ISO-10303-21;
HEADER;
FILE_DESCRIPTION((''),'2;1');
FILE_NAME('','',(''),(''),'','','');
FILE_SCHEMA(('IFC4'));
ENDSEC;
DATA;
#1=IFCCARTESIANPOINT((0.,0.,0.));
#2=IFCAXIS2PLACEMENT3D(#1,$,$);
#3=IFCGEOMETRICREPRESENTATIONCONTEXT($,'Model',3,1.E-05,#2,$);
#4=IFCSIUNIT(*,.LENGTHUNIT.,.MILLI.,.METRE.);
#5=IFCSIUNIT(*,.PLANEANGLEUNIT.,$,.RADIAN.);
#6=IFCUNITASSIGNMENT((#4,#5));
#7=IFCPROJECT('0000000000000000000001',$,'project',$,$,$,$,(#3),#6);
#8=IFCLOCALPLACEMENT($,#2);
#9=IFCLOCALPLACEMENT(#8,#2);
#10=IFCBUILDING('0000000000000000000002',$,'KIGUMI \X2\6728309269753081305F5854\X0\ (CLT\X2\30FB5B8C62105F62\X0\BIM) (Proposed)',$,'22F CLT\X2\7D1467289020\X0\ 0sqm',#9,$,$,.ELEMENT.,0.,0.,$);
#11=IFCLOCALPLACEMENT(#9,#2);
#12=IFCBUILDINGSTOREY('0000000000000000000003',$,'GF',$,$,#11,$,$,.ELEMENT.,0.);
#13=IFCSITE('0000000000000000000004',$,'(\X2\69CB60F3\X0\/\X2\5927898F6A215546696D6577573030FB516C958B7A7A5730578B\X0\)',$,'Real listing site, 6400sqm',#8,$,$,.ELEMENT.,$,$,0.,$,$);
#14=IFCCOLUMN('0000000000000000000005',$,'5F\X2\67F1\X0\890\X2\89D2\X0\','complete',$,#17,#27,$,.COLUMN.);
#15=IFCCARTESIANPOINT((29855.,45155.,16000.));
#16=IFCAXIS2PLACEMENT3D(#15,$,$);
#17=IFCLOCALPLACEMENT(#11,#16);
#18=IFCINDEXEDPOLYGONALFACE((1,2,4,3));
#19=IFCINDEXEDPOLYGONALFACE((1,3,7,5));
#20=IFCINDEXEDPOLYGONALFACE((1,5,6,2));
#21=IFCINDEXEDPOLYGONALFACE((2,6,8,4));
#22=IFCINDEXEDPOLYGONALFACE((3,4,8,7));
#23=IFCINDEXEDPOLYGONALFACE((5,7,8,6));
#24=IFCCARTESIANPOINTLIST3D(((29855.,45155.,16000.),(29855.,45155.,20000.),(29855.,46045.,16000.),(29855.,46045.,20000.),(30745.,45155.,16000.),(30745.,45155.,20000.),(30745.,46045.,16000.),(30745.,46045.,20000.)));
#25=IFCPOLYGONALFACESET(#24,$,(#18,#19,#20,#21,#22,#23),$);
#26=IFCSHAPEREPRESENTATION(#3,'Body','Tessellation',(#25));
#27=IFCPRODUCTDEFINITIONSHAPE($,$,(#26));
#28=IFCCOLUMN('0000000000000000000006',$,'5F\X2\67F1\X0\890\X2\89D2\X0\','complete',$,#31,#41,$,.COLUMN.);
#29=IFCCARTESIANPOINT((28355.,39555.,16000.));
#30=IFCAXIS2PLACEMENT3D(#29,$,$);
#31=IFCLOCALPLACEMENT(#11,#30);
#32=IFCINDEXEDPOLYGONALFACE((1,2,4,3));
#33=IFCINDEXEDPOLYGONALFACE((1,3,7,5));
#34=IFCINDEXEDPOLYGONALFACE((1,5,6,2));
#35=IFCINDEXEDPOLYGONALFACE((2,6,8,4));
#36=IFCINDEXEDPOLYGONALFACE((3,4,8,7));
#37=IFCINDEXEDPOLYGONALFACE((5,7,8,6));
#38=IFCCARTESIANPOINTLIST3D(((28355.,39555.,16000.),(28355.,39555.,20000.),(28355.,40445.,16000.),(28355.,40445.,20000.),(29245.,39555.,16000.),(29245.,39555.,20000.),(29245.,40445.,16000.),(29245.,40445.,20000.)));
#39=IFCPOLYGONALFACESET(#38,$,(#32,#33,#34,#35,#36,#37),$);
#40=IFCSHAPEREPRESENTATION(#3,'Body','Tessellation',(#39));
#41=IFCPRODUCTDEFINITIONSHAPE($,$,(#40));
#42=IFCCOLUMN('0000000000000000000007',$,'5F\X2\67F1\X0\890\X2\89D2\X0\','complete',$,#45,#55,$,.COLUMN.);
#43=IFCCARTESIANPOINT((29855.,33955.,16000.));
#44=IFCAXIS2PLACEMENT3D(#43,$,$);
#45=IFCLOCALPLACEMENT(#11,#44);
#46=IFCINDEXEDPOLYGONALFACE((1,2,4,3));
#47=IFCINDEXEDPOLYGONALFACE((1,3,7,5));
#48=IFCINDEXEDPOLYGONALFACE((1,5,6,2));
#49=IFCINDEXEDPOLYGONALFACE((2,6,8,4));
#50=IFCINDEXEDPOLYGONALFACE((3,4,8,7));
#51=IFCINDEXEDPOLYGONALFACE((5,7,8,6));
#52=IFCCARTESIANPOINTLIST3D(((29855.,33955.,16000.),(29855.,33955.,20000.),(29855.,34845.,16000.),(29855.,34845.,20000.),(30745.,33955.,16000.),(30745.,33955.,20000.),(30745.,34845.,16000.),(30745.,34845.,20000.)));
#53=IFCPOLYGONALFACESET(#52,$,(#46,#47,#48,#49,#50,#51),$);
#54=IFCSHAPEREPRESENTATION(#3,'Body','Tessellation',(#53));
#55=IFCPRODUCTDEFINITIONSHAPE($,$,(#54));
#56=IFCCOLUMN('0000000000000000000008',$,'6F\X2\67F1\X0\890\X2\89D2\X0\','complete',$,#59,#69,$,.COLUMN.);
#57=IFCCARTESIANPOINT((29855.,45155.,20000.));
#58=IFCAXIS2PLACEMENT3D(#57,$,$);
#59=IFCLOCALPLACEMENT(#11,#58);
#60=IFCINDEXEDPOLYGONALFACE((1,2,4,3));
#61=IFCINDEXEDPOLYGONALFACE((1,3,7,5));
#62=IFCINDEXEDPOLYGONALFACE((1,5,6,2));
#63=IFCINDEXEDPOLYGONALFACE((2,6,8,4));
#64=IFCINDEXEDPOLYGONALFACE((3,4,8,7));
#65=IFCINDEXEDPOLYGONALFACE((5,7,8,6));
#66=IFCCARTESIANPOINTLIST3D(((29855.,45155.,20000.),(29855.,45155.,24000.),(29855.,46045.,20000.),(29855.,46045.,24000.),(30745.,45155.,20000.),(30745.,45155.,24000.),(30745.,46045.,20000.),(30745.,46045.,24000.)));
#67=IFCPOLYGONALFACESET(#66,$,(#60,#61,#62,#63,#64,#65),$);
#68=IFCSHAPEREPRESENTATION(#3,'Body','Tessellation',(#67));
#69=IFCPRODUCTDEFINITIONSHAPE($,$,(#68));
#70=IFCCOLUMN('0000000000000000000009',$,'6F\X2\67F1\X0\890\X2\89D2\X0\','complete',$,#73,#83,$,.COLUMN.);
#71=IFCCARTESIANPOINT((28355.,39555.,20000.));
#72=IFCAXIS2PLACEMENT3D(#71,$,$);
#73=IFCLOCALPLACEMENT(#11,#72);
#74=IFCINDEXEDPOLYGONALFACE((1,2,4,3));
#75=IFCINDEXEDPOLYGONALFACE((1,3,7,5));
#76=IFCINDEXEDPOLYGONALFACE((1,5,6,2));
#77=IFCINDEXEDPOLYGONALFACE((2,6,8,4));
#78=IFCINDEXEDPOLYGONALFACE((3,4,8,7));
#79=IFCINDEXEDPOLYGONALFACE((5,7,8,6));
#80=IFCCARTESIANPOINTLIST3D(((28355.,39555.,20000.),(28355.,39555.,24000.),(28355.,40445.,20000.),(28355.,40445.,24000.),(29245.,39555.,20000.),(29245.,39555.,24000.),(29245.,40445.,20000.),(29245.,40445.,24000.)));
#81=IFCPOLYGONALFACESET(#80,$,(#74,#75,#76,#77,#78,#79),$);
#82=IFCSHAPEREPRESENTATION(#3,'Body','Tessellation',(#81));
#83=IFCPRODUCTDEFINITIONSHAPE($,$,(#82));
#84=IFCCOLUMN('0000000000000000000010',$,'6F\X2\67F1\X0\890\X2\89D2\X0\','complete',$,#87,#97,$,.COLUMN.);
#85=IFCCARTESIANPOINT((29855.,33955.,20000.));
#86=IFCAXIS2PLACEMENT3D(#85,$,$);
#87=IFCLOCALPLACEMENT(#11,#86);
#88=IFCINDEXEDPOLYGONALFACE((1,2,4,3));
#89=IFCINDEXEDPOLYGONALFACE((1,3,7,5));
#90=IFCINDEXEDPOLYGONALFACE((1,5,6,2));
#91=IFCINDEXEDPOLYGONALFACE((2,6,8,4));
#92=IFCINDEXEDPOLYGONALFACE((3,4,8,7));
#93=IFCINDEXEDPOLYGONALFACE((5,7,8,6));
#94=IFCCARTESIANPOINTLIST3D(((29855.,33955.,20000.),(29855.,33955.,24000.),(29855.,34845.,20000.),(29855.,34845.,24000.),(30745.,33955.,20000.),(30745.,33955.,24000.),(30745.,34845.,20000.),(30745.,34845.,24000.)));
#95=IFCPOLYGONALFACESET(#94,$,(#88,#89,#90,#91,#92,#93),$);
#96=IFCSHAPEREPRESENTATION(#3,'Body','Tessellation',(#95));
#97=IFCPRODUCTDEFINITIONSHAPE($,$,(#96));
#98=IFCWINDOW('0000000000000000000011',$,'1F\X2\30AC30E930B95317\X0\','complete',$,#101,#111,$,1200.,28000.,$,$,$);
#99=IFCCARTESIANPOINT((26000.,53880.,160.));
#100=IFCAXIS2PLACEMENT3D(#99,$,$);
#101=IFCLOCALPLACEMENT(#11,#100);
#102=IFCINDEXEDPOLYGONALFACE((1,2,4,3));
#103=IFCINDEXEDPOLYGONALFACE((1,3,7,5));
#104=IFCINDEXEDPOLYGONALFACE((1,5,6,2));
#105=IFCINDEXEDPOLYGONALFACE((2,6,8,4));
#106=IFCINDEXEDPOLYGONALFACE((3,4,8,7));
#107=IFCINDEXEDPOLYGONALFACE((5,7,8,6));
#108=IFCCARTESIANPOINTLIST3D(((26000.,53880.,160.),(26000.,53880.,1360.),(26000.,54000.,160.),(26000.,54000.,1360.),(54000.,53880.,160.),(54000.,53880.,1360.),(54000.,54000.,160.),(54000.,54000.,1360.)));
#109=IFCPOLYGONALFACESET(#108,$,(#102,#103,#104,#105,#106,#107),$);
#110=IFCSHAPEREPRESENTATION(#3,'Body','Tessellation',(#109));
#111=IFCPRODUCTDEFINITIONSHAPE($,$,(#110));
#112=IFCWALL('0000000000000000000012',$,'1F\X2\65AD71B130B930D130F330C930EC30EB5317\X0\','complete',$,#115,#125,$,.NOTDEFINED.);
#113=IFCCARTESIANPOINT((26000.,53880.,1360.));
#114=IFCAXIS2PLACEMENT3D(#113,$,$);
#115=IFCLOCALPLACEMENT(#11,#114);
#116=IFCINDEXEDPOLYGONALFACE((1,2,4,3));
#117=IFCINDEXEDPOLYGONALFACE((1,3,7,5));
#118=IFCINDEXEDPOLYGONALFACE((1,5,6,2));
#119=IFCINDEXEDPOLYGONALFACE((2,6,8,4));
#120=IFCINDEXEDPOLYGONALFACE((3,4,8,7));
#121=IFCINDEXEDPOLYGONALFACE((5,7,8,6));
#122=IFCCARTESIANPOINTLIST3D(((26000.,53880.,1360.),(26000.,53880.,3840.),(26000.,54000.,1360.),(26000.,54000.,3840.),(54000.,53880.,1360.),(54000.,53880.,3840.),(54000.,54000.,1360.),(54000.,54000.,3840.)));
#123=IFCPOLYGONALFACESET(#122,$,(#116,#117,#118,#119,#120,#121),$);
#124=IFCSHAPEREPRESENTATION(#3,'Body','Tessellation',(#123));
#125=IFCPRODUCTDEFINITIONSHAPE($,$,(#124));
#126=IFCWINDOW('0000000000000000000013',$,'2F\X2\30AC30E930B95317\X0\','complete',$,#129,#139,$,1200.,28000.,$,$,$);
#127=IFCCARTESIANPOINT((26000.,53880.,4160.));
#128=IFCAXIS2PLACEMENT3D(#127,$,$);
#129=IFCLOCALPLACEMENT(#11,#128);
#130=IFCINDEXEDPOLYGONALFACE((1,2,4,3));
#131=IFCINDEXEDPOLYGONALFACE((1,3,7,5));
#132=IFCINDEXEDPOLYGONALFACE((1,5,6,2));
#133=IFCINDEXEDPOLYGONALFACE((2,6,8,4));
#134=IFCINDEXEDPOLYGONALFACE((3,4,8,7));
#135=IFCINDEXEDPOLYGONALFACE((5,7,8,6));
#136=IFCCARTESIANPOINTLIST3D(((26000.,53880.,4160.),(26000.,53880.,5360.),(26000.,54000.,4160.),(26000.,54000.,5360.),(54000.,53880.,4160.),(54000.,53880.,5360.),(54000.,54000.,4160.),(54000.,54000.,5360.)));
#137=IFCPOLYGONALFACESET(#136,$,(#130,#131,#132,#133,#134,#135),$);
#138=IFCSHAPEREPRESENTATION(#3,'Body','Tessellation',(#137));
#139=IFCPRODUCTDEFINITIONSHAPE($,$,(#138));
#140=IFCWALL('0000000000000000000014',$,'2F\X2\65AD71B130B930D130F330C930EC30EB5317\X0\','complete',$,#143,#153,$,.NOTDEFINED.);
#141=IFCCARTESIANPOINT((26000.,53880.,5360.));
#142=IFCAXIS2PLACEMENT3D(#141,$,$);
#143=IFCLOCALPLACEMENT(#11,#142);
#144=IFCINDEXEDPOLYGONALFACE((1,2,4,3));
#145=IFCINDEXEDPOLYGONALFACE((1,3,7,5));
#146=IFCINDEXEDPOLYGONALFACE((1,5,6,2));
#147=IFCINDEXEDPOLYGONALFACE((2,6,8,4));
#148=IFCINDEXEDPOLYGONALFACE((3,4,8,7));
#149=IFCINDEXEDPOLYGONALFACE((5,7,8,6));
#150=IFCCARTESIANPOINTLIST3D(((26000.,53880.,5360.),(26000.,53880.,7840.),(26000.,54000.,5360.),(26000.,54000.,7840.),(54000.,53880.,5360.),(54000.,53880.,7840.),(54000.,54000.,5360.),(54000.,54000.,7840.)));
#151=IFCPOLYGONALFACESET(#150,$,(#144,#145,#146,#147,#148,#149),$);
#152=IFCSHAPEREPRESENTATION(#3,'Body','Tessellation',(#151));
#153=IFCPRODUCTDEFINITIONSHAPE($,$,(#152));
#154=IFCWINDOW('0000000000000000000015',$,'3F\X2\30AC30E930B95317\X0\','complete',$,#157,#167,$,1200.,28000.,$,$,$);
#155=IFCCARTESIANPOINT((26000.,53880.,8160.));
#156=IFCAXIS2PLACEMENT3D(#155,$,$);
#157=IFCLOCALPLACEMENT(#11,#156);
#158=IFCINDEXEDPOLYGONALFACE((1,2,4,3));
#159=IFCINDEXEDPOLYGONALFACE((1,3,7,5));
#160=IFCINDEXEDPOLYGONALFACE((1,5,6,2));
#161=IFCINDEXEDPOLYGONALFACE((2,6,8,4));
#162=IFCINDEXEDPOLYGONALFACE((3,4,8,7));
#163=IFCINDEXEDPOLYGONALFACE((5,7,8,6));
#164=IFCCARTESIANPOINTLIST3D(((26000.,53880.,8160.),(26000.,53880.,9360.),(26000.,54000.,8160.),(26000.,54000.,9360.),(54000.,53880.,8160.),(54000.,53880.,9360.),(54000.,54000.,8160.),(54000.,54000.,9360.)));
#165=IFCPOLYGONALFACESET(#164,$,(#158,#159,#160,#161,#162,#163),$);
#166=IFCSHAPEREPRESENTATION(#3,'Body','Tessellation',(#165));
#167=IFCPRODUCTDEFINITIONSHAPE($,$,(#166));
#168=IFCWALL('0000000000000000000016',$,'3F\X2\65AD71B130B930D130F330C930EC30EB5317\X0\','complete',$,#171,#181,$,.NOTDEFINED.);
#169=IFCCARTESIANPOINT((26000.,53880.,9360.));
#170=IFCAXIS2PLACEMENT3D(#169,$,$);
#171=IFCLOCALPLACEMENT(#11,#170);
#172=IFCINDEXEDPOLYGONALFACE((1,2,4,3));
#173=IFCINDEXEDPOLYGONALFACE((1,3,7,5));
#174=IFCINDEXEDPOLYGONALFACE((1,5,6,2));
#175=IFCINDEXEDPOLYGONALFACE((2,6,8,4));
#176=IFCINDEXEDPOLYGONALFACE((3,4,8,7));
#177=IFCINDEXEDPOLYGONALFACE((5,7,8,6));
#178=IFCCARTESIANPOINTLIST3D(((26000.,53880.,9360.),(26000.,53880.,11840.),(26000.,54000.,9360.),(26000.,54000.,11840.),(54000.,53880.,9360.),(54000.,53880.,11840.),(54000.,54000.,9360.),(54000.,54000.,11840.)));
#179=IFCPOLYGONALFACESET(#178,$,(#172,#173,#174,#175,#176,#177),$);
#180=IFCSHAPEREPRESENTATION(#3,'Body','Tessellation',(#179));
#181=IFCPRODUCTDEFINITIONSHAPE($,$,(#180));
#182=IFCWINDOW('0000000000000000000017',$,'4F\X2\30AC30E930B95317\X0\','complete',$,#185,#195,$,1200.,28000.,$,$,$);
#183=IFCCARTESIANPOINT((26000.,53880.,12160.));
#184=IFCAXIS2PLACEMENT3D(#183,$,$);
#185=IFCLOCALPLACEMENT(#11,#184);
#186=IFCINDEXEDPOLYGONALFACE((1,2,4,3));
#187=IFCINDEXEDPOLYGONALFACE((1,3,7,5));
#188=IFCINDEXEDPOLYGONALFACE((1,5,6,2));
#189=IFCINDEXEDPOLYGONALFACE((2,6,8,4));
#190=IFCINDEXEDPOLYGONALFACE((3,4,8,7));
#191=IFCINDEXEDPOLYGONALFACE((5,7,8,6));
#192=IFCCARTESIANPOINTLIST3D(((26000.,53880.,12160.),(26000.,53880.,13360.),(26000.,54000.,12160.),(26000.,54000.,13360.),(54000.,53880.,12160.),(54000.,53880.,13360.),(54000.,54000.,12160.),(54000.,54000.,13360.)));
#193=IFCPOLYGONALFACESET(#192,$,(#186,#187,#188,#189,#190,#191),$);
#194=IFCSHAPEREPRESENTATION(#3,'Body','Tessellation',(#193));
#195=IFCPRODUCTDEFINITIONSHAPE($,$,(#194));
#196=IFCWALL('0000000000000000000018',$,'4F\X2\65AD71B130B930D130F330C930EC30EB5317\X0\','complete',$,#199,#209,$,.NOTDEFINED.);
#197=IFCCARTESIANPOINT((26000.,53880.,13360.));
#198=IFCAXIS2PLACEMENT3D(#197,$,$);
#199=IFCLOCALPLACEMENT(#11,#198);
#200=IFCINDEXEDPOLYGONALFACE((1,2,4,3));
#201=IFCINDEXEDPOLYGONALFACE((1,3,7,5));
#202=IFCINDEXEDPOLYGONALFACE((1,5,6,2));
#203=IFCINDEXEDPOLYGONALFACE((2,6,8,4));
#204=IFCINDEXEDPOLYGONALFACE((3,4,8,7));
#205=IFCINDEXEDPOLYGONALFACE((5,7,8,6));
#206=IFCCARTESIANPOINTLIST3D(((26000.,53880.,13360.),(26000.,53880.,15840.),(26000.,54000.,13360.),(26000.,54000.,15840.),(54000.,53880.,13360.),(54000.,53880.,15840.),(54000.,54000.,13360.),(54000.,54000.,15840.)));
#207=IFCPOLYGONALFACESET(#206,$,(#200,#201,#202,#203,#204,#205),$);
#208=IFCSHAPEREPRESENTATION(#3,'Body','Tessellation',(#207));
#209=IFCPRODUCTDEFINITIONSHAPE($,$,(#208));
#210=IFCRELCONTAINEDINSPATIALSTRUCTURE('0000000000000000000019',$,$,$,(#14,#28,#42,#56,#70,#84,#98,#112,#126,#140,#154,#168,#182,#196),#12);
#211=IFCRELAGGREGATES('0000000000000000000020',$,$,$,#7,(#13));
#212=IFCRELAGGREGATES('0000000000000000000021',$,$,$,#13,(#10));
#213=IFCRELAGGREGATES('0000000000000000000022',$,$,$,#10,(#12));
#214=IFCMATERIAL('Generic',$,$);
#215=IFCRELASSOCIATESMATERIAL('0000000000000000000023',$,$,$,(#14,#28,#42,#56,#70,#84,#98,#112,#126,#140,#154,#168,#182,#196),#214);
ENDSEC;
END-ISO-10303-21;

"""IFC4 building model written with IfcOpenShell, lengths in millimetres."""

from ifc_helpers import new_model, si_unit, frame, frame_2d, origin, place, context, project, spatial, rectangle, extrude, material, element, save


model = new_model("IFC4")

# Units and contexts
model_context = context("Model", 3, precision=1e-05, world=origin())
ifc_project = project(units=[si_unit("LENGTHUNIT", "METRE", prefix="MILLI"), si_unit("PLANEANGLEUNIT", "RADIAN")], contexts=[model_context])

# Site, building, storey
site_placement = place(None, origin())
site = spatial("IfcSite", under=ifc_project, at=site_placement, Name="(構想/大規模商業敷地・公開空地型)", ObjectType="Real listing site, 6400sqm", CompositionType="ELEMENT", RefElevation=0.0)
building_placement = place(site_placement, origin())
building = spatial("IfcBuilding", under=site, at=building_placement, Name="KIGUMI 木を極めた塔 (CLT・完成形BIM) (Proposed)", ObjectType="22F CLT純木造 0sqm", CompositionType="ELEMENT", ElevationOfRefHeight=0.0, ElevationOfTerrain=0.0)
storey_placement = place(building_placement, origin())
storey = spatial("IfcBuildingStorey", under=building, at=storey_placement, Name="GF", CompositionType="ELEMENT", Elevation=0.0)

# Columns
ifc_material = material(Name="Generic")
column_1_placement = place(storey_placement, frame((29855.0, 45155.0, 16000.0)))
element("IfcColumn", 1, at=column_1_placement, inside=storey, material=ifc_material, Name="5F柱890角", Description="complete", PredefinedType="COLUMN", context=model_context, shape_type="SweptSolid", body=[
    extrude(rectangle(XDim=890.0, YDim=890.0, at=frame_2d((445.0, 445.0))), frame((29855.0, 45155.0, 16000.0)), (0.0, 0.0, 1.0), 4000.0),
])
column_2_placement = place(storey_placement, frame((28355.0, 39555.0, 16000.0)))
element("IfcColumn", 2, at=column_2_placement, inside=storey, material=ifc_material, Name="5F柱890角", Description="complete", PredefinedType="COLUMN", context=model_context, shape_type="SweptSolid", body=[
    extrude(rectangle(XDim=890.0, YDim=890.0, at=frame_2d((445.0, 445.0))), frame((28355.0, 39555.0, 16000.0)), (0.0, 0.0, 1.0), 4000.0),
])
column_3_placement = place(storey_placement, frame((29855.0, 33955.0, 16000.0)))
element("IfcColumn", 3, at=column_3_placement, inside=storey, material=ifc_material, Name="5F柱890角", Description="complete", PredefinedType="COLUMN", context=model_context, shape_type="SweptSolid", body=[
    extrude(rectangle(XDim=890.0, YDim=890.0, at=frame_2d((445.0, 445.0))), frame((29855.0, 33955.0, 16000.0)), (0.0, 0.0, 1.0), 4000.0),
])
column_4_placement = place(storey_placement, frame((29855.0, 45155.0, 20000.0)))
element("IfcColumn", 4, at=column_4_placement, inside=storey, material=ifc_material, Name="6F柱890角", Description="complete", PredefinedType="COLUMN", context=model_context, shape_type="SweptSolid", body=[
    extrude(rectangle(XDim=890.0, YDim=890.0, at=frame_2d((445.0, 445.0))), frame((29855.0, 45155.0, 20000.0)), (0.0, 0.0, 1.0), 4000.0),
])
column_5_placement = place(storey_placement, frame((28355.0, 39555.0, 20000.0)))
element("IfcColumn", 5, at=column_5_placement, inside=storey, material=ifc_material, Name="6F柱890角", Description="complete", PredefinedType="COLUMN", context=model_context, shape_type="SweptSolid", body=[
    extrude(rectangle(XDim=890.0, YDim=890.0, at=frame_2d((445.0, 445.0))), frame((28355.0, 39555.0, 20000.0)), (0.0, 0.0, 1.0), 4000.0),
])
column_6_placement = place(storey_placement, frame((29855.0, 33955.0, 20000.0)))
element("IfcColumn", 6, at=column_6_placement, inside=storey, material=ifc_material, Name="6F柱890角", Description="complete", PredefinedType="COLUMN", context=model_context, shape_type="SweptSolid", body=[
    extrude(rectangle(XDim=890.0, YDim=890.0, at=frame_2d((445.0, 445.0))), frame((29855.0, 33955.0, 20000.0)), (0.0, 0.0, 1.0), 4000.0),
])

# Window
window_1_placement = place(storey_placement, frame((26000.0, 53880.0, 160.0)))
element("IfcWindow", 7, at=window_1_placement, inside=storey, material=ifc_material, Name="1Fガラス北", Description="complete", OverallHeight=1200.0, OverallWidth=28000.0, context=model_context, shape_type="SweptSolid", body=[
    extrude(rectangle(XDim=28000.0, YDim=120.0, at=frame_2d((14000.0, 60.0))), frame((26000.0, 53880.0, 160.0)), (0.0, 0.0, 1.0), 1200.0),
])

# Wall
wall_1_placement = place(storey_placement, frame((26000.0, 53880.0, 1360.0)))
element("IfcWall", 8, at=wall_1_placement, inside=storey, material=ifc_material, Name="1F断熱スパンドレル北", Description="complete", PredefinedType="NOTDEFINED", context=model_context, shape_type="SweptSolid", body=[
    extrude(rectangle(XDim=28000.0, YDim=120.0, at=frame_2d((14000.0, 60.0))), frame((26000.0, 53880.0, 1360.0)), (0.0, 0.0, 1.0), 2480.0),
])

# Window
window_2_placement = place(storey_placement, frame((26000.0, 53880.0, 4160.0)))
element("IfcWindow", 9, at=window_2_placement, inside=storey, material=ifc_material, Name="2Fガラス北", Description="complete", OverallHeight=1200.0, OverallWidth=28000.0, context=model_context, shape_type="SweptSolid", body=[
    extrude(rectangle(XDim=28000.0, YDim=120.0, at=frame_2d((14000.0, 60.0))), frame((26000.0, 53880.0, 4160.0)), (0.0, 0.0, 1.0), 1200.0),
])

# Wall
wall_2_placement = place(storey_placement, frame((26000.0, 53880.0, 5360.0)))
element("IfcWall", 10, at=wall_2_placement, inside=storey, material=ifc_material, Name="2F断熱スパンドレル北", Description="complete", PredefinedType="NOTDEFINED", context=model_context, shape_type="SweptSolid", body=[
    extrude(rectangle(XDim=28000.0, YDim=120.0, at=frame_2d((14000.0, 60.0))), frame((26000.0, 53880.0, 5360.0)), (0.0, 0.0, 1.0), 2480.0),
])

# Window
window_3_placement = place(storey_placement, frame((26000.0, 53880.0, 8160.0)))
element("IfcWindow", 11, at=window_3_placement, inside=storey, material=ifc_material, Name="3Fガラス北", Description="complete", OverallHeight=1200.0, OverallWidth=28000.0, context=model_context, shape_type="SweptSolid", body=[
    extrude(rectangle(XDim=28000.0, YDim=120.0, at=frame_2d((14000.0, 60.0))), frame((26000.0, 53880.0, 8160.0)), (0.0, 0.0, 1.0), 1200.0),
])

# Wall
wall_3_placement = place(storey_placement, frame((26000.0, 53880.0, 9360.0)))
element("IfcWall", 12, at=wall_3_placement, inside=storey, material=ifc_material, Name="3F断熱スパンドレル北", Description="complete", PredefinedType="NOTDEFINED", context=model_context, shape_type="SweptSolid", body=[
    extrude(rectangle(XDim=28000.0, YDim=120.0, at=frame_2d((14000.0, 60.0))), frame((26000.0, 53880.0, 9360.0)), (0.0, 0.0, 1.0), 2480.0),
])

# Window
window_4_placement = place(storey_placement, frame((26000.0, 53880.0, 12160.0)))
element("IfcWindow", 13, at=window_4_placement, inside=storey, material=ifc_material, Name="4Fガラス北", Description="complete", OverallHeight=1200.0, OverallWidth=28000.0, context=model_context, shape_type="SweptSolid", body=[
    extrude(rectangle(XDim=28000.0, YDim=120.0, at=frame_2d((14000.0, 60.0))), frame((26000.0, 53880.0, 12160.0)), (0.0, 0.0, 1.0), 1200.0),
])

# Wall
wall_4_placement = place(storey_placement, frame((26000.0, 53880.0, 13360.0)))
element("IfcWall", 14, at=wall_4_placement, inside=storey, material=ifc_material, Name="4F断熱スパンドレル北", Description="complete", PredefinedType="NOTDEFINED", context=model_context, shape_type="SweptSolid", body=[
    extrude(rectangle(XDim=28000.0, YDim=120.0, at=frame_2d((14000.0, 60.0))), frame((26000.0, 53880.0, 13360.0)), (0.0, 0.0, 1.0), 2480.0),
])

save(model, "model.ifc")
